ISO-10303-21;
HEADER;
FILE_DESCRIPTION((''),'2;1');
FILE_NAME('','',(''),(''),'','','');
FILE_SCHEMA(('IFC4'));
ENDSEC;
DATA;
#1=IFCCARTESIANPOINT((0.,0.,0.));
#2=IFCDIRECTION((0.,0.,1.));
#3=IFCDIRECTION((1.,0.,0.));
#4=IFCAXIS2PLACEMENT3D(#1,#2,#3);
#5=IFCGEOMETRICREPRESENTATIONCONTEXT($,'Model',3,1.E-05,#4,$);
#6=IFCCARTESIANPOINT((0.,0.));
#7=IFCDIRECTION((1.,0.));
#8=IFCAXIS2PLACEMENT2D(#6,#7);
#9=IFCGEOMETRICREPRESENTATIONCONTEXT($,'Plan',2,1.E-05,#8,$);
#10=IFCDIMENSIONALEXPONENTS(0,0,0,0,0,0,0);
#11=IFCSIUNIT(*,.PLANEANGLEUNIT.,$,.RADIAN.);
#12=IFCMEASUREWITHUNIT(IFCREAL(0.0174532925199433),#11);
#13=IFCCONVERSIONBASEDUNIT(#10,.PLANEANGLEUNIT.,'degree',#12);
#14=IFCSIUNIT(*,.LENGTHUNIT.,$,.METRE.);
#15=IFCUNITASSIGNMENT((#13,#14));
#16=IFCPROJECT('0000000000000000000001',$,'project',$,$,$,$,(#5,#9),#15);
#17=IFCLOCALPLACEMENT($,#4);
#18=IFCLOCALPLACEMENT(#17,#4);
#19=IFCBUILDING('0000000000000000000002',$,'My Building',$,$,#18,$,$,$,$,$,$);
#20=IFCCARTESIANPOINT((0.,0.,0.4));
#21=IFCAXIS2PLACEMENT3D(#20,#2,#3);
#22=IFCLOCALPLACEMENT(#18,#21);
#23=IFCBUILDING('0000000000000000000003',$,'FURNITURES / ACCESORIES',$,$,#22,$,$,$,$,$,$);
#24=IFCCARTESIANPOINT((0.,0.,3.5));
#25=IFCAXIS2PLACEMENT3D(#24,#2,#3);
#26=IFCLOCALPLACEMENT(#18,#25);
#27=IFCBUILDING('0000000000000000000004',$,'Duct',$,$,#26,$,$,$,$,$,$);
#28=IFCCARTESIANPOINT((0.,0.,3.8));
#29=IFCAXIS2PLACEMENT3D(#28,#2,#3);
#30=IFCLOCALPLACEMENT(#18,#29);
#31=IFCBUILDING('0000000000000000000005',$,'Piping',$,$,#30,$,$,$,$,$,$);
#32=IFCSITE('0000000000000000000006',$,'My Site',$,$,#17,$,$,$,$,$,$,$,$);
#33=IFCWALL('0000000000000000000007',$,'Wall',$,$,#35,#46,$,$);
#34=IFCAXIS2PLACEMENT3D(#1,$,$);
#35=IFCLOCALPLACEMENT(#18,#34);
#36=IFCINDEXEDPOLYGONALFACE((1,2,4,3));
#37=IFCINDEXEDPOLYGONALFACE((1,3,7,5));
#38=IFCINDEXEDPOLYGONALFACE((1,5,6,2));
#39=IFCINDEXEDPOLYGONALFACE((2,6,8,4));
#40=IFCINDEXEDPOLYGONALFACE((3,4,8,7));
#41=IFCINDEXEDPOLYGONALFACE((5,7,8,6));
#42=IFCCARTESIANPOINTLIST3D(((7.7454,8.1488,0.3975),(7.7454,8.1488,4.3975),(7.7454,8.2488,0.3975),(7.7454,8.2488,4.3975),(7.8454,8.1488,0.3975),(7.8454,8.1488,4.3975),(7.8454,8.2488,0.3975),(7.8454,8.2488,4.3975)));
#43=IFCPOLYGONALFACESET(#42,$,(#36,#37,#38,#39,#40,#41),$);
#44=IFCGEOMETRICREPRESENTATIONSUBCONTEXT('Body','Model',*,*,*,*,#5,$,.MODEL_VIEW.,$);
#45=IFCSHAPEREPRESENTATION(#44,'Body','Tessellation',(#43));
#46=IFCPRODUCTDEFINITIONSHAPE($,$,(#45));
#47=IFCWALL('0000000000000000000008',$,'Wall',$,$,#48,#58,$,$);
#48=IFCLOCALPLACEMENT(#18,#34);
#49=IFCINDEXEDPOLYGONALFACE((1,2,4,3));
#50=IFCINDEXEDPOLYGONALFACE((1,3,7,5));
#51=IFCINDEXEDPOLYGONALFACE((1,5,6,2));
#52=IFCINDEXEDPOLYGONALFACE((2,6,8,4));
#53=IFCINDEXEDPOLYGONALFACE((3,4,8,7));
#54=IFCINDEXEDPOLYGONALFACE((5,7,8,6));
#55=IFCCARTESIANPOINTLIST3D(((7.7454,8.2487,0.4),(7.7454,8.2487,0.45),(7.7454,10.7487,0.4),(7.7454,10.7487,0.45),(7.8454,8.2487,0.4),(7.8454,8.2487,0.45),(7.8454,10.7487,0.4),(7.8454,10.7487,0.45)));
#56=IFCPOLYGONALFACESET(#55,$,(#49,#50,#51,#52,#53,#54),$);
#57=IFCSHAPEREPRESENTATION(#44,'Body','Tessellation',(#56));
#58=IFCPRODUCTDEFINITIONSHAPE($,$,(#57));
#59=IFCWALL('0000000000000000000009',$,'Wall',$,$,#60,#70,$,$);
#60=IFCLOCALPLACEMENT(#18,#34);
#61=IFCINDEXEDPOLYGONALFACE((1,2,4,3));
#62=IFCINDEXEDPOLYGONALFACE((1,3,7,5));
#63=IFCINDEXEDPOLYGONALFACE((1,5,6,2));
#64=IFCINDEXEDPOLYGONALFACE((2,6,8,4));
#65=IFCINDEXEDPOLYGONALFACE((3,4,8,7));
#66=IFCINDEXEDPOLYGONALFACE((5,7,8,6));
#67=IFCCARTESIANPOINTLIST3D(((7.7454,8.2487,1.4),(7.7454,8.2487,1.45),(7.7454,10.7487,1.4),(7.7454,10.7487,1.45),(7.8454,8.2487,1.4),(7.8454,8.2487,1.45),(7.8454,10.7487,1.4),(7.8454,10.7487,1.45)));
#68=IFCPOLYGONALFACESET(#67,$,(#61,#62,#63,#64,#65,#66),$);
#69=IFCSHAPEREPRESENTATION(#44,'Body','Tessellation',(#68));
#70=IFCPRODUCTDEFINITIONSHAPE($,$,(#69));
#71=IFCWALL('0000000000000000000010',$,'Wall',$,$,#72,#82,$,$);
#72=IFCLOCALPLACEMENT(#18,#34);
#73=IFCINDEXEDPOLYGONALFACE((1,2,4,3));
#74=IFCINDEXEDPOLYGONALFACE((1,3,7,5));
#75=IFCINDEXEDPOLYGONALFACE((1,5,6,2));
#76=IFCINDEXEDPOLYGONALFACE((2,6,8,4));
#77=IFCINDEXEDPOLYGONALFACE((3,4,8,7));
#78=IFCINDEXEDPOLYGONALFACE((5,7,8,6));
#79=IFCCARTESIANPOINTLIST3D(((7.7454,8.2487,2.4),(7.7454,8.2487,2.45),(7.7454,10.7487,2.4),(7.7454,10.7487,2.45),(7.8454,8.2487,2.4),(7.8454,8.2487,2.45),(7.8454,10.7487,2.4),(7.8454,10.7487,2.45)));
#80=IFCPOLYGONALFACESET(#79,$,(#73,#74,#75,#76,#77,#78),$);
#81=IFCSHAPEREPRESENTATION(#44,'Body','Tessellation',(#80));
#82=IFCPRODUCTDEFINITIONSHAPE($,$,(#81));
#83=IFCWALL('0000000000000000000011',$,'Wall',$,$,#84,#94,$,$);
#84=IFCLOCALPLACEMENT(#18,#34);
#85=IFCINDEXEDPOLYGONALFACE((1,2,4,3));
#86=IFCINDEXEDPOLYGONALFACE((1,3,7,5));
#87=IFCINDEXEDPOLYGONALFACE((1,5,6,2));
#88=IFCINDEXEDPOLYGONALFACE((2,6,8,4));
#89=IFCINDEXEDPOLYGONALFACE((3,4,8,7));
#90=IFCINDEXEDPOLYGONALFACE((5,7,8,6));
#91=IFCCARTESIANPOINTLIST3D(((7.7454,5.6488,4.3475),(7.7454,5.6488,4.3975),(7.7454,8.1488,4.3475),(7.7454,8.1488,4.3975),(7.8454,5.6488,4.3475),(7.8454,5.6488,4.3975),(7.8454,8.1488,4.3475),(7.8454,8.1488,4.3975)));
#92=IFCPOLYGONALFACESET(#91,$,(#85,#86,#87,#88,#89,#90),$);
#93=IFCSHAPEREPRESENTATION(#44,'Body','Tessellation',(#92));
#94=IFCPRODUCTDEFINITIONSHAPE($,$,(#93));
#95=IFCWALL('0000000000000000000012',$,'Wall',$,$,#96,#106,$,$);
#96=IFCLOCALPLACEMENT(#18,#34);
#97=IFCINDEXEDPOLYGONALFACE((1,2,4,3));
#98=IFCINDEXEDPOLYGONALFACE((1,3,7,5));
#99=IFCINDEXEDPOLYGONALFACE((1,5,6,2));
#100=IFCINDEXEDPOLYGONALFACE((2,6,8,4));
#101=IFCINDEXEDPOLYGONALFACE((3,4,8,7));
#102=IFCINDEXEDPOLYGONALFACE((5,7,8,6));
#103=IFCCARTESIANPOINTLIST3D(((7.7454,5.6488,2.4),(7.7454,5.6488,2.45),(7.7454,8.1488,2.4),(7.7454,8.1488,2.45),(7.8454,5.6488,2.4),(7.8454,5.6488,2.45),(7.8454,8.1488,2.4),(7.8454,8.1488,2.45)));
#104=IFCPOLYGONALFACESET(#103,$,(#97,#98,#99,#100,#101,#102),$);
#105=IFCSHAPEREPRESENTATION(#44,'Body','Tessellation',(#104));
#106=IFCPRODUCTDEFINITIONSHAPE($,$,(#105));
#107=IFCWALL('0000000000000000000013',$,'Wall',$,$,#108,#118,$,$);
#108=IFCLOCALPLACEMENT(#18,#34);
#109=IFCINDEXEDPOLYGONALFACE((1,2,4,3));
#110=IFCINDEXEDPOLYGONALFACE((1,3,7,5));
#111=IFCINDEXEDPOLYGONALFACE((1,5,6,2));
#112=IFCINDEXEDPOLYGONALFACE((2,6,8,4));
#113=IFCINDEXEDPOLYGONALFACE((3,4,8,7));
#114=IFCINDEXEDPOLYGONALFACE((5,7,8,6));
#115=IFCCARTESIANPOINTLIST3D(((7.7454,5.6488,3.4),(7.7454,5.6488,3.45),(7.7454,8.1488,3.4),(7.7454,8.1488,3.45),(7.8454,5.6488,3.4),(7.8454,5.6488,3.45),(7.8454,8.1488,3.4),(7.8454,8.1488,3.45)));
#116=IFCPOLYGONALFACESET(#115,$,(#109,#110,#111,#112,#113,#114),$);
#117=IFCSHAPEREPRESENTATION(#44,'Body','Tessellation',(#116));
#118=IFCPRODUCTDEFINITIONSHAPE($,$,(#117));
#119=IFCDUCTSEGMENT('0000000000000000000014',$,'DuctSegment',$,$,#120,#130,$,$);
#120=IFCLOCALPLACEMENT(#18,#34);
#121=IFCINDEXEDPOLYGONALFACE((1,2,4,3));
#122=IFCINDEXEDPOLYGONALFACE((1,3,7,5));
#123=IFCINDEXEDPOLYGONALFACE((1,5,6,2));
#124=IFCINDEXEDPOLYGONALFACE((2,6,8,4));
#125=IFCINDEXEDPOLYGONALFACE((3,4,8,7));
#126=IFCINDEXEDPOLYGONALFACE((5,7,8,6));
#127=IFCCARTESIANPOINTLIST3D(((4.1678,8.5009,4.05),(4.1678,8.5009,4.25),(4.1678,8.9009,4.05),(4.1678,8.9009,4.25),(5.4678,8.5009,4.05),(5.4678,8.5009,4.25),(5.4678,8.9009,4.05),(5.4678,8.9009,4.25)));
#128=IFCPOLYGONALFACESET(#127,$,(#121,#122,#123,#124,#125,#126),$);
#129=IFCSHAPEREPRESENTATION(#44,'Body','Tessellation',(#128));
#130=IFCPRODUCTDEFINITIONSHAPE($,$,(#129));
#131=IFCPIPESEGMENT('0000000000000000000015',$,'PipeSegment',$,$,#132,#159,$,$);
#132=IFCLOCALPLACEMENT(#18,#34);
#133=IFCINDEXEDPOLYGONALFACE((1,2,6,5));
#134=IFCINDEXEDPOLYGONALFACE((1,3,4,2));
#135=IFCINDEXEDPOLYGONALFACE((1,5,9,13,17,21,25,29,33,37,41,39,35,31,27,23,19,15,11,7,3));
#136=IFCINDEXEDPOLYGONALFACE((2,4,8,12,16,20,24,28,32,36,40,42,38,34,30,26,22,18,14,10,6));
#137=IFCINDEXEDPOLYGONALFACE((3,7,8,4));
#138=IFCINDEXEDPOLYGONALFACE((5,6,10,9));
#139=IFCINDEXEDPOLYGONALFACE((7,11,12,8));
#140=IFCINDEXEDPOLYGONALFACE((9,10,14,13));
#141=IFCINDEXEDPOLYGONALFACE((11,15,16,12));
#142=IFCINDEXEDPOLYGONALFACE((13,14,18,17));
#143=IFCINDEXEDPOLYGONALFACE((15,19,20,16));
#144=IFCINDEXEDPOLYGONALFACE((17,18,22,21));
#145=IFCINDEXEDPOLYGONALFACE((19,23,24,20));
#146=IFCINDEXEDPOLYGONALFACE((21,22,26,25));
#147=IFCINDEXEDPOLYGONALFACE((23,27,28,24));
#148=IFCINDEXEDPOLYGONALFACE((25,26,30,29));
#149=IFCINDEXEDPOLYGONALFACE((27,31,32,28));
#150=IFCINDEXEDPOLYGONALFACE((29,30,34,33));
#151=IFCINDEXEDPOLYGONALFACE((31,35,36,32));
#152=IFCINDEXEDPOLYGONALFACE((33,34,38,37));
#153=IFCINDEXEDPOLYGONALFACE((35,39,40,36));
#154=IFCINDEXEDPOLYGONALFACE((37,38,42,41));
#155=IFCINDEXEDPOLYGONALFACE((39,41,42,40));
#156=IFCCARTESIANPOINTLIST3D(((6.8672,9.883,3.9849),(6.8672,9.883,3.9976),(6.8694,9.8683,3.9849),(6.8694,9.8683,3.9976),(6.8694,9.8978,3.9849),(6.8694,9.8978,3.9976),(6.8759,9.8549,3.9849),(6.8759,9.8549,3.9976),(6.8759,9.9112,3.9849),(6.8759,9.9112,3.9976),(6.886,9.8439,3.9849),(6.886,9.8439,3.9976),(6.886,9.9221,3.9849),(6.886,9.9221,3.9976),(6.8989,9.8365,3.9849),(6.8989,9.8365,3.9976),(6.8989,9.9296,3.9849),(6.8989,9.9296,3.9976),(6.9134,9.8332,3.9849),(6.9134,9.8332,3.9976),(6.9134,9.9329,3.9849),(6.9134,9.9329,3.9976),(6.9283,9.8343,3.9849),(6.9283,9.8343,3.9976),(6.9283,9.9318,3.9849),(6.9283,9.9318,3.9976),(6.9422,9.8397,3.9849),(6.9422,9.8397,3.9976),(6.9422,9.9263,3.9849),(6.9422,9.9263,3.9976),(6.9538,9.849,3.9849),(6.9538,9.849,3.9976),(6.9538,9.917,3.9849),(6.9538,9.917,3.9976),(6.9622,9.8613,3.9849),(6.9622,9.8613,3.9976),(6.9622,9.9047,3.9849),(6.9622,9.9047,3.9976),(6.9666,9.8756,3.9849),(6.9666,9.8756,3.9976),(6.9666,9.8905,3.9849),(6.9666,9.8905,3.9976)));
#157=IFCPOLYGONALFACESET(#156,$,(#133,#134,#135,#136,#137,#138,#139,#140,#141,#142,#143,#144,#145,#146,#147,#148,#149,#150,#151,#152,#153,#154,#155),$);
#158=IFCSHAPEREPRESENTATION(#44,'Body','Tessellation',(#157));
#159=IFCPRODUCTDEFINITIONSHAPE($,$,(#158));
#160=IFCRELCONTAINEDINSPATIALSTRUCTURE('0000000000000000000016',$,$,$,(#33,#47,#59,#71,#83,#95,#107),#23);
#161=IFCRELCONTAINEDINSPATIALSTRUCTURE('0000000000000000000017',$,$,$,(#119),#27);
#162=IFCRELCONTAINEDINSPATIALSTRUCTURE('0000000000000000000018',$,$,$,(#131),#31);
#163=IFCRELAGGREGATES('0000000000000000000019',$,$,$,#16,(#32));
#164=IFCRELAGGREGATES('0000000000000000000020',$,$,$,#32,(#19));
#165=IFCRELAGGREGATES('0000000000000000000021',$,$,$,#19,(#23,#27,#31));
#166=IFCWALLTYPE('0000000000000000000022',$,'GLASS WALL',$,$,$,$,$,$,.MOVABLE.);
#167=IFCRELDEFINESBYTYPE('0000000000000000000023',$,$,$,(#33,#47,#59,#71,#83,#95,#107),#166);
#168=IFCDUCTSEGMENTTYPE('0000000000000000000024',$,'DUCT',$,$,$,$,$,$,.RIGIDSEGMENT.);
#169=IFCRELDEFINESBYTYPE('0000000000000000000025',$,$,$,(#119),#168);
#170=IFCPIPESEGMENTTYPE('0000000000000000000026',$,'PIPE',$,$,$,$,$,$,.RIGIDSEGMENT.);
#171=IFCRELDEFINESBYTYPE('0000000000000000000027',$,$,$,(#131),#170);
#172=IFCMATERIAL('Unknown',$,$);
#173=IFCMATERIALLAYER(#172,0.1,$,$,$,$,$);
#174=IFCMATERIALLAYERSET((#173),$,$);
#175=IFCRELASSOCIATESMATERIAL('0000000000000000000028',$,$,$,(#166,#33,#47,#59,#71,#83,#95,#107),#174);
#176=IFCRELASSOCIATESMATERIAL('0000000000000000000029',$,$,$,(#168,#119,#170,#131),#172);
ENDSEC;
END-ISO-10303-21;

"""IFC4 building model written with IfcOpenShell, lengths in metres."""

from ifc_helpers import new_model, entity, si_unit, converted_unit, frame, origin_with_axes, origin_2d_with_axis, place, context, subcontext, project, spatial, line, indexed_curve, rectangle, circle, outline, extrude, material, layer, layer_set, layer_usage, material_profile, profile_set, profile_usage, type_object, element, save


model = new_model("IFC4")

# Units and contexts
model_context = context("Model", 3, precision=1e-05, world=origin_with_axes())
plan_context = context("Plan", 2, precision=1e-05, world=origin_2d_with_axis())
body_context_1 = subcontext(model_context, "Body", "Model", "MODEL_VIEW")
ifc_project = project(units=[converted_unit("PLANEANGLEUNIT", "degree", entity("IfcReal", 0.0174532925199433), si_unit("PLANEANGLEUNIT", "RADIAN"), dimensions=[0, 0, 0, 0, 0, 0, 0]), si_unit("LENGTHUNIT", "METRE")], contexts=[model_context, plan_context])

# Site, building
site_placement = place(None, origin_with_axes())
site = spatial("IfcSite", under=ifc_project, at=site_placement, Name="My Site")
building_1_placement = place(site_placement, origin_with_axes())
building_1 = spatial("IfcBuilding", under=site, at=building_1_placement, Name="My Building")

# Shared definitions
ifc_material = material(Name="Unknown")

# Shared definitions
building_2_placement = place(building_1_placement, frame((0.0, 0.0, 0.4), z_axis=(0.0, 0.0, 1.0), x_axis=(1.0, 0.0, 0.0)))
building_2 = spatial("IfcBuilding", under=building_1, at=building_2_placement, Name="FURNITURES / ACCESORIES")

# Walls
ifc_layer_1 = layer(ifc_material, 0.1)
ifc_layer_set_1 = layer_set([ifc_layer_1])
ifc_layer_usage_1 = layer_usage(ifc_layer_set_1, "AXIS2", "POSITIVE", 0.0)
wall_type_1 = type_object("IfcWallType", Name="GLASS WALL", PredefinedType="MOVABLE", material=ifc_layer_set_1)
wall_1_placement = place(building_2_placement, frame((7.7454, 8.2488, -0.0025), z_axis=(0.0, 0.0, 1.0), x_axis=(0.0, -1.0, 0.0)))
element("IfcWall", 1, at=wall_1_placement, inside=building_2, type_object=wall_type_1, material=ifc_layer_usage_1, Name="Wall", context=body_context_1, shape_type="SweptSolid", body=[
    extrude(outline(indexed_curve([(0.0, 0.0), (0.0, 0.1), (0.1, 0.1), (0.1, 0.0)], segments=[line(1, 2, 3, 4, 1)])), origin_with_axes(), (0.0, 0.0, 1.0), 4.0),
])
ifc_layer_usage_2 = layer_usage(ifc_layer_set_1, "AXIS2", "POSITIVE", 0.0)
wall_2_placement = place(building_2_placement, frame((7.7454, 10.7487, 0.0), z_axis=(0.0, 0.0, 1.0), x_axis=(0.0, -1.0, 0.0)))
element("IfcWall", 2, at=wall_2_placement, inside=building_2, type_object=wall_type_1, material=ifc_layer_usage_2, Name="Wall", context=body_context_1, shape_type="SweptSolid", body=[
    extrude(outline(indexed_curve([(0.0, 0.0), (0.0, 0.1), (2.5, 0.1), (2.5, 0.0)], segments=[line(1, 2, 3, 4, 1)])), origin_with_axes(), (0.0, 0.0, 1.0), 0.05),
])
ifc_layer_usage_3 = layer_usage(ifc_layer_set_1, "AXIS2", "POSITIVE", 0.0)
wall_3_placement = place(building_2_placement, frame((7.7454, 10.7487, 1.0), z_axis=(0.0, 0.0, 1.0), x_axis=(0.0, -1.0, 0.0)))
element("IfcWall", 3, at=wall_3_placement, inside=building_2, type_object=wall_type_1, material=ifc_layer_usage_3, Name="Wall", context=body_context_1, shape_type="SweptSolid", body=[
    extrude(outline(indexed_curve([(0.0, 0.0), (0.0, 0.1), (2.5, 0.1), (2.5, 0.0)], segments=[line(1, 2, 3, 4, 1)])), origin_with_axes(), (0.0, 0.0, 1.0), 0.05),
])
ifc_layer_usage_4 = layer_usage(ifc_layer_set_1, "AXIS2", "POSITIVE", 0.0)
wall_4_placement = place(building_2_placement, frame((7.7454, 10.7487, 2.0), z_axis=(0.0, 0.0, 1.0), x_axis=(0.0, -1.0, 0.0)))
element("IfcWall", 4, at=wall_4_placement, inside=building_2, type_object=wall_type_1, material=ifc_layer_usage_4, Name="Wall", context=body_context_1, shape_type="SweptSolid", body=[
    extrude(outline(indexed_curve([(0.0, 0.0), (0.0, 0.1), (2.5, 0.1), (2.5, 0.0)], segments=[line(1, 2, 3, 4, 1)])), origin_with_axes(), (0.0, 0.0, 1.0), 0.05),
])
ifc_layer_usage_5 = layer_usage(ifc_layer_set_1, "AXIS2", "POSITIVE", 0.0)
wall_5_placement = place(building_2_placement, frame((7.7454, 8.1488, 3.9475), z_axis=(0.0, 0.0, 1.0), x_axis=(0.0, -1.0, 0.0)))
element("IfcWall", 5, at=wall_5_placement, inside=building_2, type_object=wall_type_1, material=ifc_layer_usage_5, Name="Wall", context=body_context_1, shape_type="SweptSolid", body=[
    extrude(outline(indexed_curve([(0.0, 0.0), (0.0, 0.1), (2.5, 0.1), (2.5, 0.0)], segments=[line(1, 2, 3, 4, 1)])), origin_with_axes(), (0.0, 0.0, 1.0), 0.05),
])
ifc_layer_usage_6 = layer_usage(ifc_layer_set_1, "AXIS2", "POSITIVE", 0.0)
wall_6_placement = place(building_2_placement, frame((7.7454, 8.1488, 2.0), z_axis=(0.0, 0.0, 1.0), x_axis=(0.0, -1.0, 0.0)))
element("IfcWall", 6, at=wall_6_placement, inside=building_2, type_object=wall_type_1, material=ifc_layer_usage_6, Name="Wall", context=body_context_1, shape_type="SweptSolid", body=[
    extrude(outline(indexed_curve([(0.0, 0.0), (0.0, 0.1), (2.5, 0.1), (2.5, 0.0)], segments=[line(1, 2, 3, 4, 1)])), origin_with_axes(), (0.0, 0.0, 1.0), 0.05),
])
ifc_layer_usage_7 = layer_usage(ifc_layer_set_1, "AXIS2", "POSITIVE", 0.0)
wall_7_placement = place(building_2_placement, frame((7.7454, 8.1488, 3.0), z_axis=(0.0, 0.0, 1.0), x_axis=(0.0, -1.0, 0.0)))
element("IfcWall", 7, at=wall_7_placement, inside=building_2, type_object=wall_type_1, material=ifc_layer_usage_7, Name="Wall", context=body_context_1, shape_type="SweptSolid", body=[
    extrude(outline(indexed_curve([(0.0, 0.0), (0.0, 0.1), (2.5, 0.1), (2.5, 0.0)], segments=[line(1, 2, 3, 4, 1)])), origin_with_axes(), (0.0, 0.0, 1.0), 0.05),
])

# Shared definitions
building_3_placement = place(building_1_placement, frame((0.0, 0.0, 3.5), z_axis=(0.0, 0.0, 1.0), x_axis=(1.0, 0.0, 0.0)))
building_3 = spatial("IfcBuilding", under=building_1, at=building_3_placement, Name="Duct")

# Duct segment
ifc_material_profile_1 = material_profile(ifc_material, rectangle(XDim=0.4, YDim=0.2))
ifc_profile_set_1 = profile_set([ifc_material_profile_1])
ifc_profile_usage_1 = profile_usage(ifc_profile_set_1, cardinal=5)
duct_segment_type = type_object("IfcDuctSegmentType", Name="DUCT", PredefinedType="RIGIDSEGMENT", material=ifc_profile_set_1)
duct_segment_placement = place(building_3_placement, frame((5.4678, 8.7009, 0.65), z_axis=(-1.0, 0.0, 0.0), x_axis=(0.0, 1.0, 0.0)))
element("IfcDuctSegment", 8, at=duct_segment_placement, inside=building_3, type_object=duct_segment_type, material=ifc_profile_usage_1, Name="DuctSegment", context=body_context_1, shape_type="SweptSolid", body=[
    extrude(rectangle(XDim=0.4, YDim=0.2), origin_with_axes(), (0.0, 0.0, 1.0), 1.3),
])

# Shared definitions
building_4_placement = place(building_1_placement, frame((0.0, 0.0, 3.8), z_axis=(0.0, 0.0, 1.0), x_axis=(1.0, 0.0, 0.0)))
building_4 = spatial("IfcBuilding", under=building_1, at=building_4_placement, Name="Piping")

# Pipe segment
ifc_material_profile_2 = material_profile(ifc_material, circle(Radius=0.05))
ifc_profile_set_2 = profile_set([ifc_material_profile_2])
ifc_profile_usage_2 = profile_usage(ifc_profile_set_2, cardinal=5)
pipe_segment_type = type_object("IfcPipeSegmentType", Name="PIPE", PredefinedType="RIGIDSEGMENT", material=ifc_profile_set_2)
pipe_segment_1_placement = place(building_4_placement, frame((6.9172, 9.883, 0.1976), z_axis=(0.0, 0.0, -1.0), x_axis=(-1.0, 0.0, 0.0)))
element("IfcPipeSegment", 9, at=pipe_segment_1_placement, inside=building_4, type_object=pipe_segment_type, material=ifc_profile_usage_2, Name="PipeSegment", context=body_context_1, shape_type="SweptSolid", body=[
    extrude(circle(Radius=0.05), origin_with_axes(), (0.0, 0.0, 1.0), 0.0127),
])

save(model, "model.ifc")
